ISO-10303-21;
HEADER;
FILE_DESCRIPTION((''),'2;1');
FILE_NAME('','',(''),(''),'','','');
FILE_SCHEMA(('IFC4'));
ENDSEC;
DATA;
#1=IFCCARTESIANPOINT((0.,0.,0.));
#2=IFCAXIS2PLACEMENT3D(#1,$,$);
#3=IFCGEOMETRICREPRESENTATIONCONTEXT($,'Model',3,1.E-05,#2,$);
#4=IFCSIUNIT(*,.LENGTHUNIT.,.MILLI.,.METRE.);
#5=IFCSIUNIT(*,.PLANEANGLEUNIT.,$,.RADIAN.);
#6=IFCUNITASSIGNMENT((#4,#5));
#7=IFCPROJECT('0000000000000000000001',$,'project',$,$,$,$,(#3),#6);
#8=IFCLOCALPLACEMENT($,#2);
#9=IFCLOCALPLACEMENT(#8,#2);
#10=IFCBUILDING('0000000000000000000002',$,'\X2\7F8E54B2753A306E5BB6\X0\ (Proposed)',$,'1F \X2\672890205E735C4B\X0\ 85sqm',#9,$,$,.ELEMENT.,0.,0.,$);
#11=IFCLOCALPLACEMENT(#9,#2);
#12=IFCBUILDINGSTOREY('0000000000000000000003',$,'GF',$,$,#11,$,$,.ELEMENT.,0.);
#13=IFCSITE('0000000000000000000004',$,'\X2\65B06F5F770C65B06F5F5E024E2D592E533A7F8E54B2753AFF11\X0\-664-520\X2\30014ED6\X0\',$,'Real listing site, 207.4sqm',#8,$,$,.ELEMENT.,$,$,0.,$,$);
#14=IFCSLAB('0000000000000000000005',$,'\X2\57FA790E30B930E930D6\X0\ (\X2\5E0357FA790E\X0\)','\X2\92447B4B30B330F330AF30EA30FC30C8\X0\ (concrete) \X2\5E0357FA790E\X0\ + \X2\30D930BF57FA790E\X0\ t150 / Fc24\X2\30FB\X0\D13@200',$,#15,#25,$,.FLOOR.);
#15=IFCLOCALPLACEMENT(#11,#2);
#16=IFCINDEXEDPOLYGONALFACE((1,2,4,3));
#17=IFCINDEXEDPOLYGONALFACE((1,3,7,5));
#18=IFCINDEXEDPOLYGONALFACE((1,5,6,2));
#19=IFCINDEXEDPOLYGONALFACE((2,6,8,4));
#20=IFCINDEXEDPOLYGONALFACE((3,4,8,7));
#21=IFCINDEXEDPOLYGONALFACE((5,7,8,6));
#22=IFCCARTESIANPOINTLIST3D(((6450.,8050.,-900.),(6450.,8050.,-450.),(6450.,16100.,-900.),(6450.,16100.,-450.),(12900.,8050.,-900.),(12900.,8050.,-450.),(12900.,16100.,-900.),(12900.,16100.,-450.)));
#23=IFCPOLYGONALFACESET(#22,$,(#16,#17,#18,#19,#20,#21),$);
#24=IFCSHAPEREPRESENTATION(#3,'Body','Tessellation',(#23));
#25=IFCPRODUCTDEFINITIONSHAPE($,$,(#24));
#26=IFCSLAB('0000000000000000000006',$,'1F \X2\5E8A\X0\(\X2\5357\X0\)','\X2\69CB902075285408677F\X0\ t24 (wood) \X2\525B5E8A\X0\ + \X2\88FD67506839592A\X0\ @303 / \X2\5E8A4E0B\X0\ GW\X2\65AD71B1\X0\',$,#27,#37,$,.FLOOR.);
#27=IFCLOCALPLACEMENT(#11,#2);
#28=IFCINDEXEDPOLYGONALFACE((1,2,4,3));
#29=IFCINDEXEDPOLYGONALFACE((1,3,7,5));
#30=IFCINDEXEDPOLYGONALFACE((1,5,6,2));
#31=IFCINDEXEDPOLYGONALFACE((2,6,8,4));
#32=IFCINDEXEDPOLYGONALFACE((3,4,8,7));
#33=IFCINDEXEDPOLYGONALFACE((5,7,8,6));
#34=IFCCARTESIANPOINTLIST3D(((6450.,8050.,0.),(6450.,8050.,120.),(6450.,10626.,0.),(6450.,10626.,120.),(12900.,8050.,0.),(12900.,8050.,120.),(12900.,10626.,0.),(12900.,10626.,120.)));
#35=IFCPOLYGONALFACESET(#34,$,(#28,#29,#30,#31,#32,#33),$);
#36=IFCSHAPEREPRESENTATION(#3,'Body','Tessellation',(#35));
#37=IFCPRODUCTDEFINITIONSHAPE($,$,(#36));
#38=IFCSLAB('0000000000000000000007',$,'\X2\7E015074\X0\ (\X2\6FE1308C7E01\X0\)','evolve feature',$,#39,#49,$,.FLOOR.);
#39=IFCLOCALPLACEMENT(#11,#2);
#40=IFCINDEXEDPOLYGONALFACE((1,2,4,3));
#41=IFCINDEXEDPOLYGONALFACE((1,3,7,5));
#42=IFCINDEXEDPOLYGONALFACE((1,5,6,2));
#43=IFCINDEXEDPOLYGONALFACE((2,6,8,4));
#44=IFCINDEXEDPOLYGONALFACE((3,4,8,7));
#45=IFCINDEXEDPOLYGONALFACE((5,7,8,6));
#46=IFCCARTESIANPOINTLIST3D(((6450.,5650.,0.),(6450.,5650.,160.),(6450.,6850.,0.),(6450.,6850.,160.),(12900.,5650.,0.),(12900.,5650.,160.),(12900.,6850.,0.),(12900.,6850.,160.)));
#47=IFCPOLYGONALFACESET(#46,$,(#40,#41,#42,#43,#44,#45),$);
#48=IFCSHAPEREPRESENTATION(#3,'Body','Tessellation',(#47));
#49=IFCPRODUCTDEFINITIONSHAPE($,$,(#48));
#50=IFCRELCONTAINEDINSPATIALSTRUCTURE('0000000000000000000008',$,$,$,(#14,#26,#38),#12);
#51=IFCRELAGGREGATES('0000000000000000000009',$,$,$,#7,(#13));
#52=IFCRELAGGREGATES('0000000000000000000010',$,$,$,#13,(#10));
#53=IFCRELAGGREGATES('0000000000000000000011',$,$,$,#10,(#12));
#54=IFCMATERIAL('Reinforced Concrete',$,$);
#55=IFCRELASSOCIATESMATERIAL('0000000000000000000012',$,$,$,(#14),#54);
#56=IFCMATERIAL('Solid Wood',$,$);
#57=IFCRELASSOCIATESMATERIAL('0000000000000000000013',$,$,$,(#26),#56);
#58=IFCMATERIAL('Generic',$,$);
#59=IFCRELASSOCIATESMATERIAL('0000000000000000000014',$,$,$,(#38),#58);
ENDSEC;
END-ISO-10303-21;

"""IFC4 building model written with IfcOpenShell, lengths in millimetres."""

from ifc_helpers import new_model, si_unit, frame, frame_2d, origin, place, context, project, spatial, rectangle, extrude, material, element, save


model = new_model("IFC4")

# Units and contexts
model_context = context("Model", 3, precision=1e-05, world=origin())
ifc_project = project(units=[si_unit("LENGTHUNIT", "METRE", prefix="MILLI"), si_unit("PLANEANGLEUNIT", "RADIAN")], contexts=[model_context])

# Site, building, storey
site_placement = place(None, origin())
site = spatial("IfcSite", under=ifc_project, at=site_placement, Name="新潟県新潟市中央区美咲町１-664-520、他", ObjectType="Real listing site, 207.4sqm", CompositionType="ELEMENT", RefElevation=0.0)
building_placement = place(site_placement, origin())
building = spatial("IfcBuilding", under=site, at=building_placement, Name="美咲町の家 (Proposed)", ObjectType="1F 木造平屋 85sqm", CompositionType="ELEMENT", ElevationOfRefHeight=0.0, ElevationOfTerrain=0.0)
storey_placement = place(building_placement, origin())
storey = spatial("IfcBuildingStorey", under=building, at=storey_placement, Name="GF", CompositionType="ELEMENT", Elevation=0.0)

# Slabs
ifc_material_1 = material(Name="Reinforced Concrete")
slab_1_placement = place(storey_placement, frame((3225.0, 4025.0, -450.0)))
element("IfcSlab", 1, at=slab_1_placement, inside=storey, material=ifc_material_1, Name="基礎スラブ (布基礎)", Description="鉄筋コンクリート (concrete) 布基礎 + ベタ基礎 t150 / Fc24・D13@200", PredefinedType="FLOOR", context=model_context, shape_type="SweptSolid", body=[
    extrude(rectangle(XDim=6450.0, YDim=8050.0, at=frame_2d((3225.0, 4025.0))), frame((3225.0, 4025.0, -450.0)), (0.0, 0.0, 1.0), 450.0),
])
ifc_material_2 = material(Name="Solid Wood")
slab_2_placement = place(storey_placement, frame((3225.0, 4025.0, 0.0)))
element("IfcSlab", 2, at=slab_2_placement, inside=storey, material=ifc_material_2, Name="1F 床(南)", Description="構造用合板 t24 (wood) 剛床 + 製材根太 @303 / 床下 GW断熱", PredefinedType="FLOOR", context=model_context, shape_type="SweptSolid", body=[
    extrude(rectangle(XDim=6450.0, YDim=2576.0, at=frame_2d((3225.0, 1288.0))), frame((3225.0, 4025.0, 0.0)), (0.0, 0.0, 1.0), 120.0),
])
ifc_material_3 = material(Name="Generic")
slab_3_placement = place(storey_placement, frame((3225.0, 2825.0, 0.0)))
element("IfcSlab", 3, at=slab_3_placement, inside=storey, material=ifc_material_3, Name="縁側 (濡れ縁)", Description="evolve feature", PredefinedType="FLOOR", context=model_context, shape_type="SweptSolid", body=[
    extrude(rectangle(XDim=6450.0, YDim=1200.0, at=frame_2d((3225.0, 600.0))), frame((3225.0, 2825.0, 0.0)), (0.0, 0.0, 1.0), 160.0),
])

save(model, "model.ifc")
